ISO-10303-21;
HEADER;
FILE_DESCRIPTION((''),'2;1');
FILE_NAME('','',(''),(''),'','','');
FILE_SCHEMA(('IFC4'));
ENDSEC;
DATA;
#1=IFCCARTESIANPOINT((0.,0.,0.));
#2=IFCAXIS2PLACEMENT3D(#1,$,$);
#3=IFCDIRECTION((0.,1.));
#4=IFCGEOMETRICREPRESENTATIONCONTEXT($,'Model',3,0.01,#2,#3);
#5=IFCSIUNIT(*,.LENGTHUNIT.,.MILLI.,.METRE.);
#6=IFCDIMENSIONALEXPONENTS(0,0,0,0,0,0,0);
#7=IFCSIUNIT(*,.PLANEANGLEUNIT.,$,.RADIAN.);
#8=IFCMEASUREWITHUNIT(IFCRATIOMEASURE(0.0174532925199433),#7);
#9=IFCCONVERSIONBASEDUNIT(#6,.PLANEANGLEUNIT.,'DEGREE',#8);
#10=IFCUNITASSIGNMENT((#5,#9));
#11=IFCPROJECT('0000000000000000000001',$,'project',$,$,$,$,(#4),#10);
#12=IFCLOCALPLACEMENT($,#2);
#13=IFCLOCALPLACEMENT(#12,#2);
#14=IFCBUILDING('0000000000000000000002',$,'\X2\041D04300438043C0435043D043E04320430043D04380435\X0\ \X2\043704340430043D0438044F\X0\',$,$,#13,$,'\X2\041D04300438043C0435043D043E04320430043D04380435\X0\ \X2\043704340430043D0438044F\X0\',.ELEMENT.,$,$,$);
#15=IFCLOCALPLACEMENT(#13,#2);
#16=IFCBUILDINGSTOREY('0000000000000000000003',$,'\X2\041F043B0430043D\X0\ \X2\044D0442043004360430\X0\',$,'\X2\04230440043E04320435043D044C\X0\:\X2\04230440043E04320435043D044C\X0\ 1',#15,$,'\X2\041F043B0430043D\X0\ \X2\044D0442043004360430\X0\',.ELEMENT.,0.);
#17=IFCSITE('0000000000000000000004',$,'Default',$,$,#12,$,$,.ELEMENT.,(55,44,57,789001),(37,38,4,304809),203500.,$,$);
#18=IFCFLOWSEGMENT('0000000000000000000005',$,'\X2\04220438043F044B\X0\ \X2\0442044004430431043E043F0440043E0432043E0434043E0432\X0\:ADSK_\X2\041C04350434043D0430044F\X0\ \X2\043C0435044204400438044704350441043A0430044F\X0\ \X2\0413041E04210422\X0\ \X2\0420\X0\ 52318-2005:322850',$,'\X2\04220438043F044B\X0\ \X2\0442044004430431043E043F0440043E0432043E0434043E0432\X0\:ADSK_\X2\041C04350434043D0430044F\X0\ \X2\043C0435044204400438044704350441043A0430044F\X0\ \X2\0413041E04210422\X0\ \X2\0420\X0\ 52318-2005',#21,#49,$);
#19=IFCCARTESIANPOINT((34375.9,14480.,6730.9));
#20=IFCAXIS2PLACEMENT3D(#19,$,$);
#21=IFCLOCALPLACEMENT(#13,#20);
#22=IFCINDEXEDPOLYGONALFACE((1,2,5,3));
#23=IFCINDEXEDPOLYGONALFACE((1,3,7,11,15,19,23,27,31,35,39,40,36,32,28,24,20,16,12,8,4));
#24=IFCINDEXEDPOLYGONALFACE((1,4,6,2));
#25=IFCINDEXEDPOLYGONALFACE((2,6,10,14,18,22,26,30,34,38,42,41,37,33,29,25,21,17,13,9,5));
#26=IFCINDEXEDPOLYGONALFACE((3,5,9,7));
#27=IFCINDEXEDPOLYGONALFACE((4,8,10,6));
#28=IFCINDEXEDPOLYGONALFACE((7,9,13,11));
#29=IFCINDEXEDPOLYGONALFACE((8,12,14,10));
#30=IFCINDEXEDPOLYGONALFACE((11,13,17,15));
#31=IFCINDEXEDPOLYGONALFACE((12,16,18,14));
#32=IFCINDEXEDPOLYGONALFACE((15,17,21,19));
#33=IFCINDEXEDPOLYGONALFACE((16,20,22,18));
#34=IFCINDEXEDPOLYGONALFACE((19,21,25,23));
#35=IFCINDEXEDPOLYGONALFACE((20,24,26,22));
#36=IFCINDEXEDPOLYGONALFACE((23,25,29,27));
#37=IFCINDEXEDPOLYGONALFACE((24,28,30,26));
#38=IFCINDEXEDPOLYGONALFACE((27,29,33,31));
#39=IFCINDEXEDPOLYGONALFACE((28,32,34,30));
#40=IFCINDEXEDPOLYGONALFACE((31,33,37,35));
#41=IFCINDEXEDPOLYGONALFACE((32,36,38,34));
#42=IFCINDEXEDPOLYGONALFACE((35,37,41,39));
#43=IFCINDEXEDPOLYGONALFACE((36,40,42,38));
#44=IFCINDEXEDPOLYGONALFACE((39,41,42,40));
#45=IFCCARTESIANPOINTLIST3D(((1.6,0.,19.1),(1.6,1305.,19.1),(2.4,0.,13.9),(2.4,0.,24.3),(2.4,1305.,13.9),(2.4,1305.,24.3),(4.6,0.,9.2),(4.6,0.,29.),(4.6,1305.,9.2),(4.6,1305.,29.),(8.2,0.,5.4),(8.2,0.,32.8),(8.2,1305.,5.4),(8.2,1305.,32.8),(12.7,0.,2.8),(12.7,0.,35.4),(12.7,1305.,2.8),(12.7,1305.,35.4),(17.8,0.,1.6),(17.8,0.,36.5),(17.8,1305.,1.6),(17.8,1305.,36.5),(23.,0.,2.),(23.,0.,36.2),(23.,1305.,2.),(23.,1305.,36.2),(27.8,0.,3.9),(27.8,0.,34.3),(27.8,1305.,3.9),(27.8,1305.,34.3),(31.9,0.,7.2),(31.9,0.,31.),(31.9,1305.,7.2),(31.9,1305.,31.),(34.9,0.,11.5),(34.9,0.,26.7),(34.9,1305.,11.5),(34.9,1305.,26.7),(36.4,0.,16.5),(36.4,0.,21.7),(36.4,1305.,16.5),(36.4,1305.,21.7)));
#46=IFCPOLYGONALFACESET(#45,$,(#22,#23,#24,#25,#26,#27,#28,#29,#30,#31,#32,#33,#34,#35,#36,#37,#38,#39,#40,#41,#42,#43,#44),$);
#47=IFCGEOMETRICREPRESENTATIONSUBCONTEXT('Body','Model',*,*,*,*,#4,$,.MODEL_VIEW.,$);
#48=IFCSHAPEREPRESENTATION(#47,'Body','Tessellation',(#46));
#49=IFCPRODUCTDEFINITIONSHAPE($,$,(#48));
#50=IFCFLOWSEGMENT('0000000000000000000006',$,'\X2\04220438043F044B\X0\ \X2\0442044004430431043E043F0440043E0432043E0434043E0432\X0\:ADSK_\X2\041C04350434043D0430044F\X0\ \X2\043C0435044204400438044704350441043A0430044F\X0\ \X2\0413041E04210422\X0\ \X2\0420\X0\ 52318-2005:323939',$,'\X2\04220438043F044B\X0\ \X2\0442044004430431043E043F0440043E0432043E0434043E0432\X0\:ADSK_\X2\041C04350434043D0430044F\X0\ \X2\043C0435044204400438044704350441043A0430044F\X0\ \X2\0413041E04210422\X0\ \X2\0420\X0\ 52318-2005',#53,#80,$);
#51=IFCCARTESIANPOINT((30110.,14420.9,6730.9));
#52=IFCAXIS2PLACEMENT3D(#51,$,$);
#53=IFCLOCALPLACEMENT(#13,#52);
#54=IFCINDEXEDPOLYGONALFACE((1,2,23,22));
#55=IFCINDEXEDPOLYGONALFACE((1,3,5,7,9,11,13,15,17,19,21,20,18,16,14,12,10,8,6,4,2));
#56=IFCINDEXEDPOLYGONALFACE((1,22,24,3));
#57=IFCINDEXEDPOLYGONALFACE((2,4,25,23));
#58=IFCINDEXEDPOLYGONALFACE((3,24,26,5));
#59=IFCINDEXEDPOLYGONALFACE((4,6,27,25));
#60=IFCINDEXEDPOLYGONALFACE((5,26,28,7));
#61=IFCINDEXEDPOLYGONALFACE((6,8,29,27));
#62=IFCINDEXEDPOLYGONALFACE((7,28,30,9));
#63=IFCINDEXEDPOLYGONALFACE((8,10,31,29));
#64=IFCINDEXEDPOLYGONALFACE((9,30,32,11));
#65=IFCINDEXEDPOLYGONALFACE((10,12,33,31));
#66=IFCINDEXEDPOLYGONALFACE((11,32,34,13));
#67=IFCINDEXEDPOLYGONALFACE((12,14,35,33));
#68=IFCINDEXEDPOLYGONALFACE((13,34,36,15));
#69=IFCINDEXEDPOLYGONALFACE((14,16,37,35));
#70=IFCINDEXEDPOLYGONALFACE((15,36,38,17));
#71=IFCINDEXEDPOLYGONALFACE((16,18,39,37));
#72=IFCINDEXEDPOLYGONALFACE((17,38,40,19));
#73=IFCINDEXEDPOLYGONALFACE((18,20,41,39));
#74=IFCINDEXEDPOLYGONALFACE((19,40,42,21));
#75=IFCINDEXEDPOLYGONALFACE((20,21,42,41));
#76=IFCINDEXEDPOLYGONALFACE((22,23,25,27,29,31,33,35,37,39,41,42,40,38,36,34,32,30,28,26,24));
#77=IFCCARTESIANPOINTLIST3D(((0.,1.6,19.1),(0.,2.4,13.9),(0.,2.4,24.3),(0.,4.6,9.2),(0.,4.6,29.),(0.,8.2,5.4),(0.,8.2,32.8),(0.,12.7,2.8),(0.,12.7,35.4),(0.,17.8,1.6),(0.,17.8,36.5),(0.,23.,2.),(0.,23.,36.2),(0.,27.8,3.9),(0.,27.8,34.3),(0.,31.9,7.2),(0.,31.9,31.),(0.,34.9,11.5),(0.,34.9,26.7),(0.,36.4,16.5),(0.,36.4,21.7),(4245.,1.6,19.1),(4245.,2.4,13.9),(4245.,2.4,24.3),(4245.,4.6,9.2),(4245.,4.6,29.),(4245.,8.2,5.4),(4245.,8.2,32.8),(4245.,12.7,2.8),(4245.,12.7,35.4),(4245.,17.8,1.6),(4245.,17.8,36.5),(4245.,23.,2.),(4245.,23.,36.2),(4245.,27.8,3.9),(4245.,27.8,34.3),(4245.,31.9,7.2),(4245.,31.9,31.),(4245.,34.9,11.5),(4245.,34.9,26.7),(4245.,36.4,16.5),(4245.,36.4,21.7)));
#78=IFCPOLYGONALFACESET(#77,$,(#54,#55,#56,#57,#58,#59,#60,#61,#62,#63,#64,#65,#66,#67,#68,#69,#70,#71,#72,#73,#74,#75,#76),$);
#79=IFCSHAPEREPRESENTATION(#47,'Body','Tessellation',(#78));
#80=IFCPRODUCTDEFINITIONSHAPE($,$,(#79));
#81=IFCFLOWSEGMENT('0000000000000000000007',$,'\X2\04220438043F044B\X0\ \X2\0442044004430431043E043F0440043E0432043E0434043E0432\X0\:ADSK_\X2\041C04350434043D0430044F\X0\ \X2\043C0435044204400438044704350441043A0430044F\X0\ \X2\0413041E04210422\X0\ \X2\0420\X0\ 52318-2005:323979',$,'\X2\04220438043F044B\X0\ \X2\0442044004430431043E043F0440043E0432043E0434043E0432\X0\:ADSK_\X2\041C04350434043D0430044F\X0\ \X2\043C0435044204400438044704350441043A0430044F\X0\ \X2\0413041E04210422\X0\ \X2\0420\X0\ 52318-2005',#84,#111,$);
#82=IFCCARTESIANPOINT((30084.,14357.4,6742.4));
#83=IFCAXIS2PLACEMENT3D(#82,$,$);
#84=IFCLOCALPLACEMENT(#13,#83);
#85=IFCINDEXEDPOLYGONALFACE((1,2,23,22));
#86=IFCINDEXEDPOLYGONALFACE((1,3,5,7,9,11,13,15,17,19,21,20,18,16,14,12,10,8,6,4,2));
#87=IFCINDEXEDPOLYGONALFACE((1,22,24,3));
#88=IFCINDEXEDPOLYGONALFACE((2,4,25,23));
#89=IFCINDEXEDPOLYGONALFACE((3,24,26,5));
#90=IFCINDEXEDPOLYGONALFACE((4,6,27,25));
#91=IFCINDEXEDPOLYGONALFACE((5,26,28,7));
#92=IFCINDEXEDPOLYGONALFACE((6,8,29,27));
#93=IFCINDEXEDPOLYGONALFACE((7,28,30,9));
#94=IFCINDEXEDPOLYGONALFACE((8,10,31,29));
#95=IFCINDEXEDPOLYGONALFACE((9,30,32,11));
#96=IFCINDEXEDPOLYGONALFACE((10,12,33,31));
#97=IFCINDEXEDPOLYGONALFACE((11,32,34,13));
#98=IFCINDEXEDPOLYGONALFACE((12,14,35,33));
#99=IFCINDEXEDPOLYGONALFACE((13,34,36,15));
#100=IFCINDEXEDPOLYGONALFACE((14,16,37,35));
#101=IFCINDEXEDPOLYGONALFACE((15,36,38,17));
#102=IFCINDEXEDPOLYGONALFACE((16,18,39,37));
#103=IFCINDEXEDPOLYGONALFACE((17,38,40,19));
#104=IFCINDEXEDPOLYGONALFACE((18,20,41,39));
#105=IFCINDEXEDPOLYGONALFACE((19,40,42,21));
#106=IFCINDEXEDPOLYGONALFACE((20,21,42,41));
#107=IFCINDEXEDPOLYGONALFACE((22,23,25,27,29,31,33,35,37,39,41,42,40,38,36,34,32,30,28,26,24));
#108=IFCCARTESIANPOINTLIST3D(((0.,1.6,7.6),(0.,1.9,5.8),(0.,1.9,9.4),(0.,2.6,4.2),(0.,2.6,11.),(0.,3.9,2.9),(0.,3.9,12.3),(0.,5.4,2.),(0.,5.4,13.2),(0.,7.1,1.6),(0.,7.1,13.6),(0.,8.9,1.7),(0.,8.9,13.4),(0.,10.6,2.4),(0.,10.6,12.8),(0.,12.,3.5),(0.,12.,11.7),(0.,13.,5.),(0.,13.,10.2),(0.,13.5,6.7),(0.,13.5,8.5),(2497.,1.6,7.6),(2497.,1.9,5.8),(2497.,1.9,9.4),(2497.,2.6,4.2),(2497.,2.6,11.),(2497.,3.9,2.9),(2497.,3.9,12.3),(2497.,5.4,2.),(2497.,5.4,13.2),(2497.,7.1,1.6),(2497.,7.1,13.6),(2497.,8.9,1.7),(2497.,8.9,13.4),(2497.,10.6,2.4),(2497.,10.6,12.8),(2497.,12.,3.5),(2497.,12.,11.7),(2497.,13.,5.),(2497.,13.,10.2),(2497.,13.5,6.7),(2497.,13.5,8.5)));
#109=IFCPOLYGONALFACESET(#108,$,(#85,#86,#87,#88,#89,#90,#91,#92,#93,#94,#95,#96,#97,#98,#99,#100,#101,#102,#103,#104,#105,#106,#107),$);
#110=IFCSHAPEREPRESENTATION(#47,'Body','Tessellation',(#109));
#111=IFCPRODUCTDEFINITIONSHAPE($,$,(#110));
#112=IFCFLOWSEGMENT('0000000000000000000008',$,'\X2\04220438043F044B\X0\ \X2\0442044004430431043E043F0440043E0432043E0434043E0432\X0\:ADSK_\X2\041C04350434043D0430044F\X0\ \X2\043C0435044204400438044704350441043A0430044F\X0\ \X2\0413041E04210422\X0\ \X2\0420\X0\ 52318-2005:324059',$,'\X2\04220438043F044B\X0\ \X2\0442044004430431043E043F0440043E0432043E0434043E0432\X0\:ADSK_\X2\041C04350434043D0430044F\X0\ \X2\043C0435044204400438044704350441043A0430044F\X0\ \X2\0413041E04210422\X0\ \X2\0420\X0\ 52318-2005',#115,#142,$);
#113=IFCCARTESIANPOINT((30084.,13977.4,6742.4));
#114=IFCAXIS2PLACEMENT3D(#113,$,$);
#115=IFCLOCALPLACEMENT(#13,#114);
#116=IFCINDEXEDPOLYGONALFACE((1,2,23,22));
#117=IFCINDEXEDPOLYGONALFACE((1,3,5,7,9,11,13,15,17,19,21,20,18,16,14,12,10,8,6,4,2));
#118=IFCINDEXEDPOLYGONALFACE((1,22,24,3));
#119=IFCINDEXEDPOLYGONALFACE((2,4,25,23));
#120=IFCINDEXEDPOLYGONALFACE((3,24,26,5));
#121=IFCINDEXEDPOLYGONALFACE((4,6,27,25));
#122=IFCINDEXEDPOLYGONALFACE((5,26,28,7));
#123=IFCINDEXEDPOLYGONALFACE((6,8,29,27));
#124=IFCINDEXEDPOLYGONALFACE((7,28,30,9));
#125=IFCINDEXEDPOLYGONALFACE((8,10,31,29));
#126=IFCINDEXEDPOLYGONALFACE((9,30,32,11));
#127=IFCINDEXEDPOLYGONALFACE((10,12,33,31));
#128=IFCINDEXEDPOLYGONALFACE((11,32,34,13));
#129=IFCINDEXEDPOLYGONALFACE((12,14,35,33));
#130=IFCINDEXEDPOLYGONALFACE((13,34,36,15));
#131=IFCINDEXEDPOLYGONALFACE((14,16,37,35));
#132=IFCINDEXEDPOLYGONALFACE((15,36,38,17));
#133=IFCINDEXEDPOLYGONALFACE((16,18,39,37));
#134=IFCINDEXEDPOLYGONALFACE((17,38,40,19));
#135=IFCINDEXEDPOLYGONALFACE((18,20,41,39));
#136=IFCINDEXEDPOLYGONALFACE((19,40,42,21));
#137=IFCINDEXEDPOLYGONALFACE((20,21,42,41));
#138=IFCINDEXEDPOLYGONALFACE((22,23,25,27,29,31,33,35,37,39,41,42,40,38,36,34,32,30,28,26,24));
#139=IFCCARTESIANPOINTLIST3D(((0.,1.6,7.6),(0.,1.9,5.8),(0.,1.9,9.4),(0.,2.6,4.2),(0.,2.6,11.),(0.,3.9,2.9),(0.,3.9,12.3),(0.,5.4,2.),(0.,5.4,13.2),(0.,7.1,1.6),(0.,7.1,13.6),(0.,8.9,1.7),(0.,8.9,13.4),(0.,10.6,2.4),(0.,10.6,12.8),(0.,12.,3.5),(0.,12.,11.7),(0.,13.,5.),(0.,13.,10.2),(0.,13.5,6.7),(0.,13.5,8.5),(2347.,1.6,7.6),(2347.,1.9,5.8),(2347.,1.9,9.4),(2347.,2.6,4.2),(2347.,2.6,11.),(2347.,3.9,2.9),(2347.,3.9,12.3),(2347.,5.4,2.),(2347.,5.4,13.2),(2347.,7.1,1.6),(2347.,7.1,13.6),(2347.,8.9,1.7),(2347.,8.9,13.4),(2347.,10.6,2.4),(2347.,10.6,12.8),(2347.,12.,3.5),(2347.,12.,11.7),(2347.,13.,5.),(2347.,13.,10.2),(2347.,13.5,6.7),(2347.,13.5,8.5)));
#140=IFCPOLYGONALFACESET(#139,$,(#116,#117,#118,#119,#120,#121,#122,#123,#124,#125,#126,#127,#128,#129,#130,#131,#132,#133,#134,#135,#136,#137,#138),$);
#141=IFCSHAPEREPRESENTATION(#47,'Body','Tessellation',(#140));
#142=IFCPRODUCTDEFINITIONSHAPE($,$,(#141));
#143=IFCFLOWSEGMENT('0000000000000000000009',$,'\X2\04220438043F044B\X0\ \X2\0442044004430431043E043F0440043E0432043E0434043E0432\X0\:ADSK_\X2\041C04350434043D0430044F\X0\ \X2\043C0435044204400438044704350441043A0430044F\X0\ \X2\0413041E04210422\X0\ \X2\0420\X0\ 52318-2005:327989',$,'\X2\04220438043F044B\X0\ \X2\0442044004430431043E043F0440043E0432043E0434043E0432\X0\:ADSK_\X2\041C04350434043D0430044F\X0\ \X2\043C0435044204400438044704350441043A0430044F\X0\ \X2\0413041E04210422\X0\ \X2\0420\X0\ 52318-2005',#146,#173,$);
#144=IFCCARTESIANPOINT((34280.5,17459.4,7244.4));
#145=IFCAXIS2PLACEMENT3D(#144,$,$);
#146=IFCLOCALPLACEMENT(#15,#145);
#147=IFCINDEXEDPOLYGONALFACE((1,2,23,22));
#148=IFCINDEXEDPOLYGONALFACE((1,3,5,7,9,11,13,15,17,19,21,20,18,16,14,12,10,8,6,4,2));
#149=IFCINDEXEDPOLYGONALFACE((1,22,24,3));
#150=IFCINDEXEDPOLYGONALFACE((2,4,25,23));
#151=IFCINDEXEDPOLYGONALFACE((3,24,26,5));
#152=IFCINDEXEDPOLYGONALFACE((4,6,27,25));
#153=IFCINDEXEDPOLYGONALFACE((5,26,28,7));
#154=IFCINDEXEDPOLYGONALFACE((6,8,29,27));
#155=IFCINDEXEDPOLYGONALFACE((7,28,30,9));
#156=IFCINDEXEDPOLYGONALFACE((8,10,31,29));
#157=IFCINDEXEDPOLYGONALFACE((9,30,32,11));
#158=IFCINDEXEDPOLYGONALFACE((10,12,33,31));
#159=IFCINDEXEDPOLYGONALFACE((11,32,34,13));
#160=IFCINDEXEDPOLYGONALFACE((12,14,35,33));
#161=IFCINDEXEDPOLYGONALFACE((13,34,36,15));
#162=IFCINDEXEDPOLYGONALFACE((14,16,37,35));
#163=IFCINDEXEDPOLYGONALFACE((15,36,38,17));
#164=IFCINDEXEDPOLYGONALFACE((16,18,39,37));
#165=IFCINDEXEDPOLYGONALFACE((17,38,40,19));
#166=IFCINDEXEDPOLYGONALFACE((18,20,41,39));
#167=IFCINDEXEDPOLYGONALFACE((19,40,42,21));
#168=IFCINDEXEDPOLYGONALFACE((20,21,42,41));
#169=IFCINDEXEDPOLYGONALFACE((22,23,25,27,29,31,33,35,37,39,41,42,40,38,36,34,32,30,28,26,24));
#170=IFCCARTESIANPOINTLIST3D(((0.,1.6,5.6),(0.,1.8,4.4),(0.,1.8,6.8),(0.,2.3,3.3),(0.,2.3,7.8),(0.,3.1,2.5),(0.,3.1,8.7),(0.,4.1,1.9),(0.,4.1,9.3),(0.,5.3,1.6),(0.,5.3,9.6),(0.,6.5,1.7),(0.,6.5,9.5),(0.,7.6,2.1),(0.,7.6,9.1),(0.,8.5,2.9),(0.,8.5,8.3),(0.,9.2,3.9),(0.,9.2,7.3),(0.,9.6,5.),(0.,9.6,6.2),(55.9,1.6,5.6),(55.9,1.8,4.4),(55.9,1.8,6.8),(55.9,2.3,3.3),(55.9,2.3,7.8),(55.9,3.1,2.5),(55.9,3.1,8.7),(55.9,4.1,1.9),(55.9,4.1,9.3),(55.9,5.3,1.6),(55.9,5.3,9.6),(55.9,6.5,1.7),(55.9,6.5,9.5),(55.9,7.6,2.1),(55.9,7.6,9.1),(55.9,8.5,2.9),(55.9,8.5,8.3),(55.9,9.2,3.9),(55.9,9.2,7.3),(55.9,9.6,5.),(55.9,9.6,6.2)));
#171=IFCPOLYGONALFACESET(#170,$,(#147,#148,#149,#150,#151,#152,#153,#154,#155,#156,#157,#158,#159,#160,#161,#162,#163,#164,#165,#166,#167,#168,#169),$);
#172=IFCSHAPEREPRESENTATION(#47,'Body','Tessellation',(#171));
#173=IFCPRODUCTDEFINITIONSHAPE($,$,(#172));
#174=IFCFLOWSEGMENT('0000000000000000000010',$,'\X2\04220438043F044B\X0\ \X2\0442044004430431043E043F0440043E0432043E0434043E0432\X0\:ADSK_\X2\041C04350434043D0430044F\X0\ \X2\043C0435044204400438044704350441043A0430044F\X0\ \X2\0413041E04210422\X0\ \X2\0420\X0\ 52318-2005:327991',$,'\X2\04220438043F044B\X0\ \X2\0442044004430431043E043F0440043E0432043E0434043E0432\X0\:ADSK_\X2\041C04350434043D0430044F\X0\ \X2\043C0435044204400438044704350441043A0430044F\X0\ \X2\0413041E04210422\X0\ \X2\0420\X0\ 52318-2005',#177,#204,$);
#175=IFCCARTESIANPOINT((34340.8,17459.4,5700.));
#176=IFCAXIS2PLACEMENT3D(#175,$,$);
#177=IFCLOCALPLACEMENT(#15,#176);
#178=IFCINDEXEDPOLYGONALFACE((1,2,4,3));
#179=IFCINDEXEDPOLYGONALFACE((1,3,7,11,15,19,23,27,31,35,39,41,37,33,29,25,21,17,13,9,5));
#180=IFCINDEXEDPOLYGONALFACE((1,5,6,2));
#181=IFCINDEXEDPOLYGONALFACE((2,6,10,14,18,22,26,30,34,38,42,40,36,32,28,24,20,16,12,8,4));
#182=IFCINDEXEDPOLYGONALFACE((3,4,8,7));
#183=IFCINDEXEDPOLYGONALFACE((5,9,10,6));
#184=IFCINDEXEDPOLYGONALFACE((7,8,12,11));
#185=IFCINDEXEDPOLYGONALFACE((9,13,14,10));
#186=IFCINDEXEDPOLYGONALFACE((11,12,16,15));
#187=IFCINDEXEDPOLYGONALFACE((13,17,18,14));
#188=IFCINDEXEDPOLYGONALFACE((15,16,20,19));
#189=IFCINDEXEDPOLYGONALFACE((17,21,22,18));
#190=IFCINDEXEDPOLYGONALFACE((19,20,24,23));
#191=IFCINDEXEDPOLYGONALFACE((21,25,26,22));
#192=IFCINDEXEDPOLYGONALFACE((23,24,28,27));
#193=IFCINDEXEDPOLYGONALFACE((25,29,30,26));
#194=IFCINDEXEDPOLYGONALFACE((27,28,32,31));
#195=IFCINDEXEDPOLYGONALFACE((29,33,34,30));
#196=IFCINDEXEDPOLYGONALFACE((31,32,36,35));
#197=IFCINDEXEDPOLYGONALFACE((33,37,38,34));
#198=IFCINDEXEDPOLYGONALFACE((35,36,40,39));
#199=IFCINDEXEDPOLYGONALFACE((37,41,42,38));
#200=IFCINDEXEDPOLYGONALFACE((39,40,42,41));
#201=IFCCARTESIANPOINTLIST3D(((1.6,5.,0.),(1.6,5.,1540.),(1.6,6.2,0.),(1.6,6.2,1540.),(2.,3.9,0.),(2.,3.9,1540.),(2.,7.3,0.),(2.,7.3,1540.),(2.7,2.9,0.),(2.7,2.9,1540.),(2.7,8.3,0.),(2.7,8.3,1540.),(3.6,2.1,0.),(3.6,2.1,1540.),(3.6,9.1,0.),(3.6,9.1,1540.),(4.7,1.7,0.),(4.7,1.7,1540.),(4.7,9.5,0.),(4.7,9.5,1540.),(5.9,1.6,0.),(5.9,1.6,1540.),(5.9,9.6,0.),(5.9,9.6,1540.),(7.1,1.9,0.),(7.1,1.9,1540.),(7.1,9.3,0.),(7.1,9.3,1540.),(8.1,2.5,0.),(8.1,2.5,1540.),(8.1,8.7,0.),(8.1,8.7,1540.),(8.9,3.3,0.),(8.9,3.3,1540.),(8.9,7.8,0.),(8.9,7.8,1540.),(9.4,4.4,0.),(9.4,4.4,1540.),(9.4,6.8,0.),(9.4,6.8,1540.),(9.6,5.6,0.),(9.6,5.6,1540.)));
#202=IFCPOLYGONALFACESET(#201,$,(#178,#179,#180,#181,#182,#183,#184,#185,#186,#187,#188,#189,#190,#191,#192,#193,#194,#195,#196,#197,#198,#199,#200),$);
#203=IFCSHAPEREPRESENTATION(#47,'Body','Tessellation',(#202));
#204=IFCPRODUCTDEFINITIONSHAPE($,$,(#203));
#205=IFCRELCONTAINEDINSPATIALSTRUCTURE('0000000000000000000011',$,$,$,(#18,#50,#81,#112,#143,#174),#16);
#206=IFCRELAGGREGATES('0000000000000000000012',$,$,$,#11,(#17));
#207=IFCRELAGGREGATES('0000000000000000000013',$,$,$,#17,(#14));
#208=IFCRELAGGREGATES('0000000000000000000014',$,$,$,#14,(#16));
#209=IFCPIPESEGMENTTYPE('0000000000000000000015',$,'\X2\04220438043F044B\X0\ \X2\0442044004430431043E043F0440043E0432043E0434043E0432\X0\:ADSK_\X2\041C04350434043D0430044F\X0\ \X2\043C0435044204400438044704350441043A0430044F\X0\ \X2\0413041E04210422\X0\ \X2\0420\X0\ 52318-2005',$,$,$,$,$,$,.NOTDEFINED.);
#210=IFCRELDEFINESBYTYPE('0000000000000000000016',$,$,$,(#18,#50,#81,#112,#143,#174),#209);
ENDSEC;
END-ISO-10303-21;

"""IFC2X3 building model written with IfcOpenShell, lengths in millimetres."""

from ifc_helpers import new_model, entity, si_unit, converted_unit, direction, frame, frame_2d, origin, origin_2d_with_axis, place, context, subcontext, project, spatial, circle, extrude, type_object, element, save


model = new_model("IFC2X3")

# Units and contexts
model_context = context("Model", 3, precision=0.01, world=origin(), true_north=direction((0.0, 1.0)))
body_context = subcontext(model_context, "Body", "Model", "MODEL_VIEW")
ifc_project = project(units=[si_unit("LENGTHUNIT", "METRE", prefix="MILLI"), converted_unit("PLANEANGLEUNIT", "DEGREE", entity("IfcRatioMeasure", 0.0174532925199433), si_unit("PLANEANGLEUNIT", "RADIAN"), dimensions=[0, 0, 0, 0, 0, 0, 0])], contexts=[model_context])

# Site, building, storey
site_placement = place(None, frame((0.0, 0.0, 0.0)))
site = spatial("IfcSite", under=ifc_project, at=site_placement, Name="Default", CompositionType="ELEMENT", RefLatitude=(55, 44, 57, 789001), RefLongitude=(37, 38, 4, 304809), RefElevation=203500.0)
building_placement = place(site_placement, origin())
building = spatial("IfcBuilding", under=site, at=building_placement, Name="Наименование здания", LongName="Наименование здания", CompositionType="ELEMENT")
storey_placement = place(building_placement, origin())
storey = spatial("IfcBuildingStorey", under=building, at=storey_placement, Name="План этажа", ObjectType="Уровень:Уровень 1", LongName="План этажа", CompositionType="ELEMENT", Elevation=0.0)

# Flow segments
pipe_segment_type = type_object("IfcPipeSegmentType", Name="Типы трубопроводов:ADSK_Медная метрическая ГОСТ Р 52318-2005", PredefinedType="NOTDEFINED")
flow_segment_1_placement = place(building_placement, frame((34375.9, 14480.0, 6730.9)))
element("IfcFlowSegment", 1, at=flow_segment_1_placement, inside=storey, type_object=pipe_segment_type, Name="Типы трубопроводов:ADSK_Медная метрическая ГОСТ Р 52318-2005:322850", ObjectType="Типы трубопроводов:ADSK_Медная метрическая ГОСТ Р 52318-2005", context=body_context, shape_type="SweptSolid", body=[
    extrude(circle(Radius=17.5, at=frame_2d((0.0, 0.0), x_axis=(1.0, 0.0))), frame((19.1, 0.0, 19.1), z_axis=(0.0, 1.0, 0.0), x_axis=(-1.0, 0.0, 0.0)), (0.0, 0.0, 1.0), 1305.0),
])
flow_segment_2_placement = place(building_placement, frame((30110.0, 14420.9, 6730.9)))
element("IfcFlowSegment", 2, at=flow_segment_2_placement, inside=storey, type_object=pipe_segment_type, Name="Типы трубопроводов:ADSK_Медная метрическая ГОСТ Р 52318-2005:323939", ObjectType="Типы трубопроводов:ADSK_Медная метрическая ГОСТ Р 52318-2005", context=body_context, shape_type="SweptSolid", body=[
    extrude(circle(Radius=17.5, at=origin_2d_with_axis()), frame((0.0, 19.1, 19.1), z_axis=(1.0, 0.0, 0.0), x_axis=(0.0, -1.0, 0.0)), (0.0, 0.0, 1.0), 4245.0),
])
flow_segment_3_placement = place(building_placement, frame((30084.0, 14357.4, 6742.4)))
element("IfcFlowSegment", 3, at=flow_segment_3_placement, inside=storey, type_object=pipe_segment_type, Name="Типы трубопроводов:ADSK_Медная метрическая ГОСТ Р 52318-2005:323979", ObjectType="Типы трубопроводов:ADSK_Медная метрическая ГОСТ Р 52318-2005", context=body_context, shape_type="SweptSolid", body=[
    extrude(circle(Radius=6.0, at=origin_2d_with_axis()), frame((0.0, 7.6, 7.6), z_axis=(1.0, 0.0, 0.0), x_axis=(0.0, -1.0, 0.0)), (0.0, 0.0, 1.0), 2497.0),
])
flow_segment_4_placement = place(building_placement, frame((30084.0, 13977.4, 6742.4)))
element("IfcFlowSegment", 4, at=flow_segment_4_placement, inside=storey, type_object=pipe_segment_type, Name="Типы трубопроводов:ADSK_Медная метрическая ГОСТ Р 52318-2005:324059", ObjectType="Типы трубопроводов:ADSK_Медная метрическая ГОСТ Р 52318-2005", context=body_context, shape_type="SweptSolid", body=[
    extrude(circle(Radius=6.0, at=frame_2d((0.0, 0.0), x_axis=(1.0, 0.0))), frame((0.0, 7.6, 7.6), z_axis=(1.0, 0.0, 0.0), x_axis=(0.0, -1.0, 0.0)), (0.0, 0.0, 1.0), 2347.0),
])
flow_segment_5_placement = place(storey_placement, frame((34280.5, 17459.4, 7244.4)))
element("IfcFlowSegment", 5, at=flow_segment_5_placement, inside=storey, type_object=pipe_segment_type, Name="Типы трубопроводов:ADSK_Медная метрическая ГОСТ Р 52318-2005:327989", ObjectType="Типы трубопроводов:ADSK_Медная метрическая ГОСТ Р 52318-2005", context=body_context, shape_type="SweptSolid", body=[
    extrude(circle(Radius=4.0, at=origin_2d_with_axis()), frame((0.0, 5.6, 5.6), z_axis=(1.0, 0.0, 0.0), x_axis=(0.0, -1.0, 0.0)), (0.0, 0.0, 1.0), 55.9),
])
flow_segment_6_placement = place(storey_placement, frame((34340.8, 17459.4, 5700.0)))
element("IfcFlowSegment", 6, at=flow_segment_6_placement, inside=storey, type_object=pipe_segment_type, Name="Типы трубопроводов:ADSK_Медная метрическая ГОСТ Р 52318-2005:327991", ObjectType="Типы трубопроводов:ADSK_Медная метрическая ГОСТ Р 52318-2005", context=body_context, shape_type="SweptSolid", body=[
    extrude(circle(Radius=4.0, at=origin_2d_with_axis()), frame((5.6, 5.6, 0.0)), (0.0, 0.0, 1.0), 1540.0),
])

save(model, "model.ifc")
